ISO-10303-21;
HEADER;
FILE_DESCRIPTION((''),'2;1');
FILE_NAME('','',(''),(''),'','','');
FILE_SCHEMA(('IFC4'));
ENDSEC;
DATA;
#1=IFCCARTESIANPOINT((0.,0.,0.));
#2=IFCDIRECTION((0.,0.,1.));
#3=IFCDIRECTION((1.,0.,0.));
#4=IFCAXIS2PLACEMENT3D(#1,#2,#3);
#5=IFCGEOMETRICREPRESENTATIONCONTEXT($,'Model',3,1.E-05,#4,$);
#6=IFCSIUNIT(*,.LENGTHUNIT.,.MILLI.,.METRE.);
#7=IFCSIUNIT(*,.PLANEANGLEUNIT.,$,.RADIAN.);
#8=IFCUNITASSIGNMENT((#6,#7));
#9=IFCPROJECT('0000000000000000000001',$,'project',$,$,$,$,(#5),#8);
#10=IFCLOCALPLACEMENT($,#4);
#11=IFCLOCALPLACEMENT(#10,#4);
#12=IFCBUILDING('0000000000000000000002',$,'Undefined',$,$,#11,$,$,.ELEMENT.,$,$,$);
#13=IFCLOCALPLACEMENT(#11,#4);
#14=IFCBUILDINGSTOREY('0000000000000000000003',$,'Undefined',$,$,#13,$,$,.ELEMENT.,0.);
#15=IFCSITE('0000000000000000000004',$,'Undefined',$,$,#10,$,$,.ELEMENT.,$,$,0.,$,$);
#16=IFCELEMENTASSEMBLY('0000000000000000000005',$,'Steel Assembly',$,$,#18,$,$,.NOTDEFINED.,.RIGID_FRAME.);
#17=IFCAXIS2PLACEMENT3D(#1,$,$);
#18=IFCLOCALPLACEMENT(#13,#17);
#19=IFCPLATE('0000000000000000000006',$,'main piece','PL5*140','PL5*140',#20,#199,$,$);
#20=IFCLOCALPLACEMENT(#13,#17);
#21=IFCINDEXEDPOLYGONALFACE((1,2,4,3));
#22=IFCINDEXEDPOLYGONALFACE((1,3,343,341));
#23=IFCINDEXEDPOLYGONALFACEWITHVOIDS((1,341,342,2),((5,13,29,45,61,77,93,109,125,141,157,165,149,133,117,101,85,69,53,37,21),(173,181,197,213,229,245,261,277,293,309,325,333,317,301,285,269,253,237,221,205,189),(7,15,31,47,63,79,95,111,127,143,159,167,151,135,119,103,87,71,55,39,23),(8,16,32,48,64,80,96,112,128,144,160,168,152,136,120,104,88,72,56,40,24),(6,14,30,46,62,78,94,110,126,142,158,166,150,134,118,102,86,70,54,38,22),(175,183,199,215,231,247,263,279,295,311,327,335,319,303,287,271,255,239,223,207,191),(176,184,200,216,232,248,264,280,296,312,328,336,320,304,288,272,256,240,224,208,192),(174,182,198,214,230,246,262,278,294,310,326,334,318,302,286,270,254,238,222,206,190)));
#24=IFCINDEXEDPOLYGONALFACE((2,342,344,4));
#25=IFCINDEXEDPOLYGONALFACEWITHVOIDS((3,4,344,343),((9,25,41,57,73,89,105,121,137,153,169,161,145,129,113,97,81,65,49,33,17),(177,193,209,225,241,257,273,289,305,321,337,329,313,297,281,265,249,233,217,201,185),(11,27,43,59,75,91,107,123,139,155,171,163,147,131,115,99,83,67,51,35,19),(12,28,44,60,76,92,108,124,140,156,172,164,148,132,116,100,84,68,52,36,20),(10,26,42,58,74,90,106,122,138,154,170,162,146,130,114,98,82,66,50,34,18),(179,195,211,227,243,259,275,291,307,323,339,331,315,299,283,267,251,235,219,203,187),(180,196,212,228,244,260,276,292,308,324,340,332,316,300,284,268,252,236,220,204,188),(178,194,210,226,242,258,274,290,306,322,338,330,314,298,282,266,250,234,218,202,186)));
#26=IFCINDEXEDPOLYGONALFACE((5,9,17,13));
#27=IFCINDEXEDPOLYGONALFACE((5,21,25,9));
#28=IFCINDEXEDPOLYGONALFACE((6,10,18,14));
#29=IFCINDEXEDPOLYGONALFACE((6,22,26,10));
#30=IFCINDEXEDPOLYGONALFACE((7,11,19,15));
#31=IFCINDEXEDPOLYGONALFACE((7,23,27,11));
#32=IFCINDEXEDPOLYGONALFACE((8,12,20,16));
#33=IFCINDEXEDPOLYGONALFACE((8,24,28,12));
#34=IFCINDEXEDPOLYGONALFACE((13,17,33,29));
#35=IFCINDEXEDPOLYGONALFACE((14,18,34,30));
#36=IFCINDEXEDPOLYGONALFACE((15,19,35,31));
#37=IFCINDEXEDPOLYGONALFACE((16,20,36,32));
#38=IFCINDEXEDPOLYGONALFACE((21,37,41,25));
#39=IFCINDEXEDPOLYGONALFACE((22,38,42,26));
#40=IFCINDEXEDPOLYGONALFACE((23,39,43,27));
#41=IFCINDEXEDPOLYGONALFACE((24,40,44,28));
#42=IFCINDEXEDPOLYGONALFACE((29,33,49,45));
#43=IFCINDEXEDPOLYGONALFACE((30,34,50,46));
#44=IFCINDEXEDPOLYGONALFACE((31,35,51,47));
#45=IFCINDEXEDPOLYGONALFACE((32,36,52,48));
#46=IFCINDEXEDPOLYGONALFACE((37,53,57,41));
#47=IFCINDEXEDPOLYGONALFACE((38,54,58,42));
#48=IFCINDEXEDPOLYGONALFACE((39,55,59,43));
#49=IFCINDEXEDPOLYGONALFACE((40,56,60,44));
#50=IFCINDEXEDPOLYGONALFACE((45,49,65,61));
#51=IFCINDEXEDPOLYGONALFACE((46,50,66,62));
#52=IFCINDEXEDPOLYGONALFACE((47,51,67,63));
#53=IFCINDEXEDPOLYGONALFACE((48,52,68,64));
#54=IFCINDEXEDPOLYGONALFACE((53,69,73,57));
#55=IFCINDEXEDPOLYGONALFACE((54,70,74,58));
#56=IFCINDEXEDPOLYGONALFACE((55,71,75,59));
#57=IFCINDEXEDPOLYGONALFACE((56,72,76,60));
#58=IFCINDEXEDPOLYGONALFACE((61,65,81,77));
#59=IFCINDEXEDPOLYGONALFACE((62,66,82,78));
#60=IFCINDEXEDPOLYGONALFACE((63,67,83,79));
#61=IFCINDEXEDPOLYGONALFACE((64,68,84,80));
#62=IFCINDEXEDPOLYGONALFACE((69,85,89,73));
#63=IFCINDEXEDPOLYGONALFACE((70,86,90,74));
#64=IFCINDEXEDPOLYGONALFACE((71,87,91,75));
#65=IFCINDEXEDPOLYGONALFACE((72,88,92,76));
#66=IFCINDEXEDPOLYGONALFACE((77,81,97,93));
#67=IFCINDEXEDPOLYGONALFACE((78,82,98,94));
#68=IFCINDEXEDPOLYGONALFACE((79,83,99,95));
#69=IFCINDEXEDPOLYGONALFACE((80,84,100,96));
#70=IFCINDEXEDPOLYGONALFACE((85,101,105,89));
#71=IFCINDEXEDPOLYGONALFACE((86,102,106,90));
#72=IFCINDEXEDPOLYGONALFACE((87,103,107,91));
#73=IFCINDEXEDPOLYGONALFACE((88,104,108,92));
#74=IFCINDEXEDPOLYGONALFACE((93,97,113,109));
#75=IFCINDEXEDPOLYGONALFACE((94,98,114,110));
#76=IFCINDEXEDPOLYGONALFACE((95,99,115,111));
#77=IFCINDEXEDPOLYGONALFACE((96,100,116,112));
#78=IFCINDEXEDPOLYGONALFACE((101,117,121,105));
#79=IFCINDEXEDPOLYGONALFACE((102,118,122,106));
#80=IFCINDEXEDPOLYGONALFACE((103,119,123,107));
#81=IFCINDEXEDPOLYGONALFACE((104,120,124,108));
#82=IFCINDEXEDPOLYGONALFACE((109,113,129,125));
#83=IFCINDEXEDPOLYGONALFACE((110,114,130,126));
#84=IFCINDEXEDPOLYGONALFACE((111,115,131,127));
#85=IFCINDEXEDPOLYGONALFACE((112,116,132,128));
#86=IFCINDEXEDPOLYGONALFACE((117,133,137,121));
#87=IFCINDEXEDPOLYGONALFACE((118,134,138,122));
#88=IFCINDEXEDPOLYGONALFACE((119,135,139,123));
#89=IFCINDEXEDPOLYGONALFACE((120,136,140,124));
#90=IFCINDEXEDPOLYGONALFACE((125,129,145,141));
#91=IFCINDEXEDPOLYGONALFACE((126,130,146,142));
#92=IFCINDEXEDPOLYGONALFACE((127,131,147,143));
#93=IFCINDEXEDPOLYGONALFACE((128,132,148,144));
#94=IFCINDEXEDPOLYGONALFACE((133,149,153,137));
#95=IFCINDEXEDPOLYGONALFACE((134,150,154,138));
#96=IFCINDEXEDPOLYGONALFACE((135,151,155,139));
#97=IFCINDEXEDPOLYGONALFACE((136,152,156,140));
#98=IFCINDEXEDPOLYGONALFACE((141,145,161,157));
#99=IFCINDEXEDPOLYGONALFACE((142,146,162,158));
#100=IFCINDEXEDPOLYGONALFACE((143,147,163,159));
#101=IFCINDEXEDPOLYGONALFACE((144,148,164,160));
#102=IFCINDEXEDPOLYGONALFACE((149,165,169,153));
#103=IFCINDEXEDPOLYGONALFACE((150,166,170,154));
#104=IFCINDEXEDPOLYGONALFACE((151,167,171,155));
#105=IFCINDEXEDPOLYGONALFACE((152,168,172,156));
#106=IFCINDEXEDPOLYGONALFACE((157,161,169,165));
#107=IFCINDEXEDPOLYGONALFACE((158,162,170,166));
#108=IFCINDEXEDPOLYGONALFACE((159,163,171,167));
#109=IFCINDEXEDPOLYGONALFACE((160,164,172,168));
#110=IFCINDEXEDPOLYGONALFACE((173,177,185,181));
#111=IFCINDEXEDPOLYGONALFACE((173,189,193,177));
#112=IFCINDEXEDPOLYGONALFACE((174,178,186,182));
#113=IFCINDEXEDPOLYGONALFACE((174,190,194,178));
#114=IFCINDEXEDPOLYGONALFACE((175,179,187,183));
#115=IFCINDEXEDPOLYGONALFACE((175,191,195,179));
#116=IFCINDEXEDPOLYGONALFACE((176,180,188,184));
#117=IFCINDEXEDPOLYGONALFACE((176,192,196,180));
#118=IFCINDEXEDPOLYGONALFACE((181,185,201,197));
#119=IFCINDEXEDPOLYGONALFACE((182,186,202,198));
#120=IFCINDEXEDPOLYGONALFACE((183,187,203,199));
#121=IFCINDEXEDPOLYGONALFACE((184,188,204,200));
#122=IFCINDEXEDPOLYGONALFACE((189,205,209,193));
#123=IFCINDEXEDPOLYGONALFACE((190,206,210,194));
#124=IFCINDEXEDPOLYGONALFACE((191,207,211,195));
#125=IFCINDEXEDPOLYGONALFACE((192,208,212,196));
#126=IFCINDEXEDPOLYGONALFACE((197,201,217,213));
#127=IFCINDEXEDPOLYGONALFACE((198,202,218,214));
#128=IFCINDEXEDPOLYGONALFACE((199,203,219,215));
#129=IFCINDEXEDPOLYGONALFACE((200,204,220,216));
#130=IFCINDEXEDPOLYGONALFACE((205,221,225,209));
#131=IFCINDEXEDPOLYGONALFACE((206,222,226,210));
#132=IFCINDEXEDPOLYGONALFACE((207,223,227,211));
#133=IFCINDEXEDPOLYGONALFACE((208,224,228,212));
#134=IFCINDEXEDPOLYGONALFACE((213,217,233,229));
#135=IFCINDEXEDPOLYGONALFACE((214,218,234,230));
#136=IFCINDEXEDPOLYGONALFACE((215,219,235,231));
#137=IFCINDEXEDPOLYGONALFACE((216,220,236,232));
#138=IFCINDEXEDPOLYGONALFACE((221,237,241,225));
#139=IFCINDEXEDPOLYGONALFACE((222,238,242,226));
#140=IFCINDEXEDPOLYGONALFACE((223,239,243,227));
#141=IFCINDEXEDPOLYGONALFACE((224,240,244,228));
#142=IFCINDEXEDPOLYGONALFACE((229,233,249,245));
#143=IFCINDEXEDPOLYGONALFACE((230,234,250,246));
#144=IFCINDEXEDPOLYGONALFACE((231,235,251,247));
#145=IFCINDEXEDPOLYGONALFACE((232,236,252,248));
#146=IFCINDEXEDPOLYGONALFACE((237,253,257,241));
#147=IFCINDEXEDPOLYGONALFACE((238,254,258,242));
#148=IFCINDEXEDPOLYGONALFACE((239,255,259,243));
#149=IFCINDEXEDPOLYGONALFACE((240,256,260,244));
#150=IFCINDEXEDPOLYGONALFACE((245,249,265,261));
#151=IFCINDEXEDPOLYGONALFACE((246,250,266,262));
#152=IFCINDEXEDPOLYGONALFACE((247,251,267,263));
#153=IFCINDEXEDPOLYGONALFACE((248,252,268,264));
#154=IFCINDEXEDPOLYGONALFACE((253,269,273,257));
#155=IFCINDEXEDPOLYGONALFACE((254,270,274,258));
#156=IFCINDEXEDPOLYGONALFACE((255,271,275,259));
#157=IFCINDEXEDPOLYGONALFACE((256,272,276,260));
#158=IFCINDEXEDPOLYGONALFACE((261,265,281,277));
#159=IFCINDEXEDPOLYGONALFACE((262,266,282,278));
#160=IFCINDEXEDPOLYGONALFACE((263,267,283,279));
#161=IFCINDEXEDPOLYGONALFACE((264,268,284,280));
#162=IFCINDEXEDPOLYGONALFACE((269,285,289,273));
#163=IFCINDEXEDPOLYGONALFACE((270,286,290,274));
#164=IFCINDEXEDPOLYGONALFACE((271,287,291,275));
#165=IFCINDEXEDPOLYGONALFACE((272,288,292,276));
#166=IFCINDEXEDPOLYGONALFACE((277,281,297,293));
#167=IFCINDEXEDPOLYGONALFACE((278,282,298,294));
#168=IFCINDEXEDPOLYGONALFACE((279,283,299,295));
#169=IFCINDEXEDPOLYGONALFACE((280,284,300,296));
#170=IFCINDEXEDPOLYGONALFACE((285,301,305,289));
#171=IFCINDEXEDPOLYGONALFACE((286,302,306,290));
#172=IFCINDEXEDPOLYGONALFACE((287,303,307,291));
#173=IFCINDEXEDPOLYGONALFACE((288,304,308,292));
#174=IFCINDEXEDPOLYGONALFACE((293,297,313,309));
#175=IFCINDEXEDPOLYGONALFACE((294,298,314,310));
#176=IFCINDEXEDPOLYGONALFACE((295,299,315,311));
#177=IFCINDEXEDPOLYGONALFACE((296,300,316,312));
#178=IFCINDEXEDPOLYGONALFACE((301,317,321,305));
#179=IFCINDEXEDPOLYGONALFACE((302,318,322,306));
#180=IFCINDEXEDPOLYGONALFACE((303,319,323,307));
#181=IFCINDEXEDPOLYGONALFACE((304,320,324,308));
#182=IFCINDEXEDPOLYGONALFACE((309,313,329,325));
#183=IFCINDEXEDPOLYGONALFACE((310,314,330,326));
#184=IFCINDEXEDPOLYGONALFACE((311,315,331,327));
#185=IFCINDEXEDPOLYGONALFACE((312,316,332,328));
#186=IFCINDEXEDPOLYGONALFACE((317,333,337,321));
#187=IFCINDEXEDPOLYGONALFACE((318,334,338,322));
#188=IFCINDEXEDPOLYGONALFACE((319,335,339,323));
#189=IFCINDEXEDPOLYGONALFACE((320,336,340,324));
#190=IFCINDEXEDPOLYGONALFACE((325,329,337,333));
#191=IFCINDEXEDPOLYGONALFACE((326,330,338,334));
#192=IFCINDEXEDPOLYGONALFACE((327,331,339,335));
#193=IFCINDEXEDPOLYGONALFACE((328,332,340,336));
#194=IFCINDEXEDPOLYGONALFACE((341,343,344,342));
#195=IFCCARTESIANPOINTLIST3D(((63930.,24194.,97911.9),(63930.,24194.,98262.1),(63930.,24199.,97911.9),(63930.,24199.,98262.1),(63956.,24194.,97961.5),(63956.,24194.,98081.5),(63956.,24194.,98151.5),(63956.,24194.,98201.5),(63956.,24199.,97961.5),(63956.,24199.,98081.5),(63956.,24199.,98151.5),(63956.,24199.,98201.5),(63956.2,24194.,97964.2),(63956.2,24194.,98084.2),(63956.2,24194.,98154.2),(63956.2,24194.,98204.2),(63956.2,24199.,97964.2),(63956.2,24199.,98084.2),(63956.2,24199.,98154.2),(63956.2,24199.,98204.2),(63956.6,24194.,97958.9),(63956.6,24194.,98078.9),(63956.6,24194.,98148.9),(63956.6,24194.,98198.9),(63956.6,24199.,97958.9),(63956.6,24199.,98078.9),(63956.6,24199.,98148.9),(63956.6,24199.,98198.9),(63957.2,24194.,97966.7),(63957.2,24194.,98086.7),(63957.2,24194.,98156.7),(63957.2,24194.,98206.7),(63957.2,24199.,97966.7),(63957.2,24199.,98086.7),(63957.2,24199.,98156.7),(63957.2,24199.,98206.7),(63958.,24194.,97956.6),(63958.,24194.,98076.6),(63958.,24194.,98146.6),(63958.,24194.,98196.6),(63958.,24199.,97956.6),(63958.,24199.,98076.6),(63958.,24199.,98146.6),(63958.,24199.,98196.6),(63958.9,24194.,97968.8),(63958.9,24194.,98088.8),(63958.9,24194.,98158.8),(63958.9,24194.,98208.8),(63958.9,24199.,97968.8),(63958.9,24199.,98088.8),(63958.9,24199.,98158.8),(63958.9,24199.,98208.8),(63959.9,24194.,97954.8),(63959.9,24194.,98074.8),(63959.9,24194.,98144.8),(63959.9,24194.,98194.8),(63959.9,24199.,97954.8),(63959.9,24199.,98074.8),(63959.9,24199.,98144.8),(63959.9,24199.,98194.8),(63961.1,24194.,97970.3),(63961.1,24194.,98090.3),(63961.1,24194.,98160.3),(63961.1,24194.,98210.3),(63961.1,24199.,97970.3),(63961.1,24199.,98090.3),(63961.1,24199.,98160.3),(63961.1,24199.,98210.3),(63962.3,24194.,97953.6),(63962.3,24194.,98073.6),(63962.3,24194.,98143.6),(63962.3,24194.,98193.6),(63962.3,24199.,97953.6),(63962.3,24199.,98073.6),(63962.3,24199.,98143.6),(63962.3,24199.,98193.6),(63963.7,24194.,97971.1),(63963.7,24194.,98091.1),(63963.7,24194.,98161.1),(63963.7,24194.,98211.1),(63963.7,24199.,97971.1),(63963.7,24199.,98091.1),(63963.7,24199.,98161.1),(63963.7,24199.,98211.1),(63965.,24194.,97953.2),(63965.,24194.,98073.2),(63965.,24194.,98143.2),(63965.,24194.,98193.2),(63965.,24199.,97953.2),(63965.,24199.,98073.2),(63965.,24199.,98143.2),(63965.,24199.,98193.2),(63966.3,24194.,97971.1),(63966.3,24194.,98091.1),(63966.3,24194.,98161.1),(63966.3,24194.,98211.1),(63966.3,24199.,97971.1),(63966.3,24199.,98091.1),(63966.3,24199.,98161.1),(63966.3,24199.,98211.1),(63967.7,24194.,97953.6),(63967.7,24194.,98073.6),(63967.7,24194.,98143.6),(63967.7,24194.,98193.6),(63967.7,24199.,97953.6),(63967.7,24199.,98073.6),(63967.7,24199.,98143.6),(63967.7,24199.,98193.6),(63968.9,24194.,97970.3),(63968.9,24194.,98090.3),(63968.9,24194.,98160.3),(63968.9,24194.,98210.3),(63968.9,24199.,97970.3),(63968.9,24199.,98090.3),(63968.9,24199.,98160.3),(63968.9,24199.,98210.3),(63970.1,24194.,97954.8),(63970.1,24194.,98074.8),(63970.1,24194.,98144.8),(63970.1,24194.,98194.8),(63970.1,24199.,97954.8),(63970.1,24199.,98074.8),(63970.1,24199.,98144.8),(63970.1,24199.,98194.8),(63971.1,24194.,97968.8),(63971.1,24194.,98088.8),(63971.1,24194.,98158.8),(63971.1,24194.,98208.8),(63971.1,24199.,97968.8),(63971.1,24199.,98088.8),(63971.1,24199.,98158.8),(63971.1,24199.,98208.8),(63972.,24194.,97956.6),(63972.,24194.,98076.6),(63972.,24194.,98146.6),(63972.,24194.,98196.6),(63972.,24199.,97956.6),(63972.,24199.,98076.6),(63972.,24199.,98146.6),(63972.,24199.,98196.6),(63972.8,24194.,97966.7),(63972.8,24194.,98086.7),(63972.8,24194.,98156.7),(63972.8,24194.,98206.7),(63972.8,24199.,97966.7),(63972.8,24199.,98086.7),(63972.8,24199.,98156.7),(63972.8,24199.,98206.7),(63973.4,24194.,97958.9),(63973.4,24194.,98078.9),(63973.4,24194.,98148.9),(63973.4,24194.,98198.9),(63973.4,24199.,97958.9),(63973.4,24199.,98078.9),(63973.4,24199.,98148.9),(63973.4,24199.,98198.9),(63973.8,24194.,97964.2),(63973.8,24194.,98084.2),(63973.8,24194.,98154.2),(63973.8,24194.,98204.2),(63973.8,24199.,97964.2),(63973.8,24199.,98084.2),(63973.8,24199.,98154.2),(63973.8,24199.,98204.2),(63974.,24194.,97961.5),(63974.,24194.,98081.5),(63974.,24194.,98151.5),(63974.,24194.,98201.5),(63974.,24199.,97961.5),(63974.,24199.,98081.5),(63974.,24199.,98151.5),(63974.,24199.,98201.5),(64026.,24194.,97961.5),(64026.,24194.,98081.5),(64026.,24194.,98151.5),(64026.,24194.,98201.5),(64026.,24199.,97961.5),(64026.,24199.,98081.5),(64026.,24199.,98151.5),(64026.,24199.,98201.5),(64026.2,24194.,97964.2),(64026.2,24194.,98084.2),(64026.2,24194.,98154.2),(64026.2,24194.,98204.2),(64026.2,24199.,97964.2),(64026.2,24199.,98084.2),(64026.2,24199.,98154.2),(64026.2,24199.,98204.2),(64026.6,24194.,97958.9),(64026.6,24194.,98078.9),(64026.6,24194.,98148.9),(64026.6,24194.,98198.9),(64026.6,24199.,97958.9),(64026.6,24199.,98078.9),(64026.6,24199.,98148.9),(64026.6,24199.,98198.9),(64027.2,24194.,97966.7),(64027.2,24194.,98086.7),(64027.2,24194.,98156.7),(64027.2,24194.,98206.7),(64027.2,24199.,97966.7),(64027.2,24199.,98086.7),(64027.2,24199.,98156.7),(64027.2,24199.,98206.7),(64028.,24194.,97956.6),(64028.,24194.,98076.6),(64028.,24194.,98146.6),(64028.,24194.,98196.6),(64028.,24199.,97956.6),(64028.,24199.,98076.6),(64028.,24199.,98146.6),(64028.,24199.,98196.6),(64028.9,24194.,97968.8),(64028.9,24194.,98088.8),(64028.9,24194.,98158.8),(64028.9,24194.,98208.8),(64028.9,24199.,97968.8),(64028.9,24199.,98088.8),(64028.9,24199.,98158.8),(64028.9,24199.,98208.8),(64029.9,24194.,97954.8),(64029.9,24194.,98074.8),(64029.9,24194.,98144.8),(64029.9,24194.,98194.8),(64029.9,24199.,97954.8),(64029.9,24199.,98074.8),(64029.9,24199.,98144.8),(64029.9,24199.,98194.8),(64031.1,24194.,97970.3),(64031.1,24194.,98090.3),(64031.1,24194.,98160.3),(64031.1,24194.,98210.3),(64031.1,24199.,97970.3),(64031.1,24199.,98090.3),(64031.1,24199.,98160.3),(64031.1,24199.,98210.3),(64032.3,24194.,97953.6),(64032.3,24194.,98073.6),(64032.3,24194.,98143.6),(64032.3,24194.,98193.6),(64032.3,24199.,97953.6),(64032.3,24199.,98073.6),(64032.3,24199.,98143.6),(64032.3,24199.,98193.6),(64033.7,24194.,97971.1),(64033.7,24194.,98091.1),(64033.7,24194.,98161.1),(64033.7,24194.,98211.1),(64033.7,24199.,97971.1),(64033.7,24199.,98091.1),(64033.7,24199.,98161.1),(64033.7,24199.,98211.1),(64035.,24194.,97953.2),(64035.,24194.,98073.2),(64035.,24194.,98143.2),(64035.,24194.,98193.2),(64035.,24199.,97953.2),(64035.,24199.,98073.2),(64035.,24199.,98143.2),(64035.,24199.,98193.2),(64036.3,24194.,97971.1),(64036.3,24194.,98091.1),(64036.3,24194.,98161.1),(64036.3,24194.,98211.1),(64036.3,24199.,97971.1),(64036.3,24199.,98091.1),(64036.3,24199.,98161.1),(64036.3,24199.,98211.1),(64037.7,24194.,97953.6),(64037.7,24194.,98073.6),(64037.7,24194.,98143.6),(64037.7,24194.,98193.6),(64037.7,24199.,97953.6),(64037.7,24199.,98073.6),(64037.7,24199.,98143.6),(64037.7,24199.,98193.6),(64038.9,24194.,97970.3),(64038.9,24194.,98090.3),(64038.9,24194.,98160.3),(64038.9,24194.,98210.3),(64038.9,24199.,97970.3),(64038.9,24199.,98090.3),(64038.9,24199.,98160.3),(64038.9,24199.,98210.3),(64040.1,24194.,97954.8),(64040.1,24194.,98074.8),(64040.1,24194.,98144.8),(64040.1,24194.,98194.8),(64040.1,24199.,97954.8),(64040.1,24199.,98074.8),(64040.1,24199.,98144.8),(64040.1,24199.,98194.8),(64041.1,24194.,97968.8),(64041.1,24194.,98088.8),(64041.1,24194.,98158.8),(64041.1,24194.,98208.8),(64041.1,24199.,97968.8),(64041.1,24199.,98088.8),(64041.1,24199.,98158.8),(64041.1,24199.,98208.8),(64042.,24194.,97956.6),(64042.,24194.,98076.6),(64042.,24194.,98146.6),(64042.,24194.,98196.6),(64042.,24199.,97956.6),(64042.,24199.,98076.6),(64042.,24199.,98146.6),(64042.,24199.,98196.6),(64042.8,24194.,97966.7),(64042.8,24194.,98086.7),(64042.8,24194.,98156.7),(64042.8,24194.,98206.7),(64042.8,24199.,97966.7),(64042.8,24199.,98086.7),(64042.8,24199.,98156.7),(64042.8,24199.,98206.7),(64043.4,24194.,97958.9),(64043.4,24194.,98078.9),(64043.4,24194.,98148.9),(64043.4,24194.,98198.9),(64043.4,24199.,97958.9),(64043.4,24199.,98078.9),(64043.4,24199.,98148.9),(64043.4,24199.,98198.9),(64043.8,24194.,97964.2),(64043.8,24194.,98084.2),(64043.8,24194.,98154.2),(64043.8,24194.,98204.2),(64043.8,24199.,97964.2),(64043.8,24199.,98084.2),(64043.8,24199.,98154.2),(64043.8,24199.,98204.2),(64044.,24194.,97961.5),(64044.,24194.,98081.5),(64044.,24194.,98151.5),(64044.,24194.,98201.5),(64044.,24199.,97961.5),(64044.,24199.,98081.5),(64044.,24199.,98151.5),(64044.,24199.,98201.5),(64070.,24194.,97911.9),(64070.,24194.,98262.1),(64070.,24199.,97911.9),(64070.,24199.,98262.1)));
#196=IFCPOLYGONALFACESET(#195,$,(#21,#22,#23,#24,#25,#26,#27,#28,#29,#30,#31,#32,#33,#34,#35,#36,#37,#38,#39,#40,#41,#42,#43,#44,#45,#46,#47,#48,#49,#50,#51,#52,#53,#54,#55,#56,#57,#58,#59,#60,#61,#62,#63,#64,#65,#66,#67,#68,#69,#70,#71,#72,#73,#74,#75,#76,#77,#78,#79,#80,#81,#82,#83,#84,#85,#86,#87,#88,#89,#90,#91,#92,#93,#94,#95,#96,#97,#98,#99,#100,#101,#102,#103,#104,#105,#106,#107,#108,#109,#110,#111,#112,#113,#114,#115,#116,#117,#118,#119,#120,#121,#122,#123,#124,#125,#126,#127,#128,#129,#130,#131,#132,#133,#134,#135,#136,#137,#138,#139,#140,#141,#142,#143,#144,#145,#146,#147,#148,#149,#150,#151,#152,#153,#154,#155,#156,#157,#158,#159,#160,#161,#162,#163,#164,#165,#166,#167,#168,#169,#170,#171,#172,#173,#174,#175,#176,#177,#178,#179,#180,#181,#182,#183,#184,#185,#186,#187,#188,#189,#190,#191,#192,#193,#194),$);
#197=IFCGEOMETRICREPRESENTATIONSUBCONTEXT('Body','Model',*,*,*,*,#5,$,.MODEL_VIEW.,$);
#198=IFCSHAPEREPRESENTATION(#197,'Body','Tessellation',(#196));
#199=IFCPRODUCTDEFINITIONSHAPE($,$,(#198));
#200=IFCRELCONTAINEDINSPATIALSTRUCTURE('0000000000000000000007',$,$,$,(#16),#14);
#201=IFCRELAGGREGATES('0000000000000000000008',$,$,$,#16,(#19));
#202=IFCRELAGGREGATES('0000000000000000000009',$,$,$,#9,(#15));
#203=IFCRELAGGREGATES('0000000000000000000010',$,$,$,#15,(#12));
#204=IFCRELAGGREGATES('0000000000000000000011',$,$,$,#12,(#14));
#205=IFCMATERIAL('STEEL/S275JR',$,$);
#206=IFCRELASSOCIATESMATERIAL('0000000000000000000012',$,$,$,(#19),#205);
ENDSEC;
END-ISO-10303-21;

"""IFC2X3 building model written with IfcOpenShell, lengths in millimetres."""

from ifc_helpers import new_model, si_unit, frame, origin_with_axes, origin_2d_with_axis, place, context, subcontext, project, spatial, polyline, circle, outline, extrude, source, transform, mapped, material, element, aggregate, save


model = new_model("IFC2X3")

# Units and contexts
model_context = context("Model", 3, precision=1e-05, world=origin_with_axes())
body_context = subcontext(model_context, "Body", "Model", "MODEL_VIEW")
ifc_project = project(units=[si_unit("LENGTHUNIT", "METRE", prefix="MILLI"), si_unit("PLANEANGLEUNIT", "RADIAN")], contexts=[model_context])

# Site, building, storey
site_placement = place(None, origin_with_axes())
site = spatial("IfcSite", under=ifc_project, at=site_placement, Name="Undefined", CompositionType="ELEMENT", RefElevation=0.0)
building_placement = place(site_placement, origin_with_axes())
building = spatial("IfcBuilding", under=site, at=building_placement, Name="Undefined", CompositionType="ELEMENT")
storey_placement = place(building_placement, origin_with_axes())
storey = spatial("IfcBuildingStorey", under=building, at=storey_placement, Name="Undefined", CompositionType="ELEMENT", Elevation=0.0)

# Element assembly, plate, opening
assembly_1_placement = place(storey_placement, origin_with_axes())
assembly_1 = element("IfcElementAssembly", 1, at=assembly_1_placement, inside=storey, Name="Steel Assembly", AssemblyPlace="NOTDEFINED", PredefinedType="RIGID_FRAME")
ifc_material_1 = material(Name="STEEL/S275JR")
plate_1_placement = place(assembly_1_placement, frame((63930.0, 24196.5, 97911.9), z_axis=(0.0, -1.0, 0.0), x_axis=(1.0, 0.0, 0.0)))
plate_1 = element("IfcPlate", 2, at=plate_1_placement, material=ifc_material_1, Name="main piece", Description="PL5*140", ObjectType="PL5*140", context=body_context, shape_type="SweptSolid", body=[
    extrude(outline(polyline([(0.0, 0.0), (140.0, 0.0), (140.0, 350.2), (0.0, 350.2), (0.0, 0.0)])), frame((0.0, 0.0, -2.5), z_axis=(0.0, 0.0, 1.0), x_axis=(1.0, 0.0, 0.0)), (0.0, 0.0, 1.0), 5.0),
])
shared_shape_1 = source(origin_with_axes(), body_context, "Body", "SweptSolid", [
    extrude(circle(Radius=9.0, at=origin_2d_with_axis()), frame((0.0, 11.9, 0.0), z_axis=(0.0, 1.0, 0.0), x_axis=(1.0, 0.0, 0.0)), (0.0, 0.0, 1.0), 17.1),
])
opening_1_placement = place(assembly_1_placement, frame((64000.0, 24182.0, 98202.2), z_axis=(1.0, 0.0, 0.0), x_axis=(0.0, 0.0, -1.0)))
element("IfcOpeningElement", 3, at=opening_1_placement, cuts=plate_1, ObjectType="Opening", context=body_context, shape_type="MappedRepresentation", body=[
    mapped(shared_shape_1, transform((0.0, 0.0, -35.0))),
    mapped(shared_shape_1, transform((50.0, 0.0, -35.0))),
    mapped(shared_shape_1, transform((120.0, 0.0, -35.0))),
    mapped(shared_shape_1, transform((240.0, 0.0, -35.0))),
    mapped(shared_shape_1, transform((0.0, 0.0, 35.0))),
    mapped(shared_shape_1, transform((50.0, 0.0, 35.0))),
    mapped(shared_shape_1, transform((120.0, 0.0, 35.0))),
    mapped(shared_shape_1, transform((240.0, 0.0, 35.0))),
])
aggregate(assembly_1, [plate_1])

save(model, "model.ifc")
